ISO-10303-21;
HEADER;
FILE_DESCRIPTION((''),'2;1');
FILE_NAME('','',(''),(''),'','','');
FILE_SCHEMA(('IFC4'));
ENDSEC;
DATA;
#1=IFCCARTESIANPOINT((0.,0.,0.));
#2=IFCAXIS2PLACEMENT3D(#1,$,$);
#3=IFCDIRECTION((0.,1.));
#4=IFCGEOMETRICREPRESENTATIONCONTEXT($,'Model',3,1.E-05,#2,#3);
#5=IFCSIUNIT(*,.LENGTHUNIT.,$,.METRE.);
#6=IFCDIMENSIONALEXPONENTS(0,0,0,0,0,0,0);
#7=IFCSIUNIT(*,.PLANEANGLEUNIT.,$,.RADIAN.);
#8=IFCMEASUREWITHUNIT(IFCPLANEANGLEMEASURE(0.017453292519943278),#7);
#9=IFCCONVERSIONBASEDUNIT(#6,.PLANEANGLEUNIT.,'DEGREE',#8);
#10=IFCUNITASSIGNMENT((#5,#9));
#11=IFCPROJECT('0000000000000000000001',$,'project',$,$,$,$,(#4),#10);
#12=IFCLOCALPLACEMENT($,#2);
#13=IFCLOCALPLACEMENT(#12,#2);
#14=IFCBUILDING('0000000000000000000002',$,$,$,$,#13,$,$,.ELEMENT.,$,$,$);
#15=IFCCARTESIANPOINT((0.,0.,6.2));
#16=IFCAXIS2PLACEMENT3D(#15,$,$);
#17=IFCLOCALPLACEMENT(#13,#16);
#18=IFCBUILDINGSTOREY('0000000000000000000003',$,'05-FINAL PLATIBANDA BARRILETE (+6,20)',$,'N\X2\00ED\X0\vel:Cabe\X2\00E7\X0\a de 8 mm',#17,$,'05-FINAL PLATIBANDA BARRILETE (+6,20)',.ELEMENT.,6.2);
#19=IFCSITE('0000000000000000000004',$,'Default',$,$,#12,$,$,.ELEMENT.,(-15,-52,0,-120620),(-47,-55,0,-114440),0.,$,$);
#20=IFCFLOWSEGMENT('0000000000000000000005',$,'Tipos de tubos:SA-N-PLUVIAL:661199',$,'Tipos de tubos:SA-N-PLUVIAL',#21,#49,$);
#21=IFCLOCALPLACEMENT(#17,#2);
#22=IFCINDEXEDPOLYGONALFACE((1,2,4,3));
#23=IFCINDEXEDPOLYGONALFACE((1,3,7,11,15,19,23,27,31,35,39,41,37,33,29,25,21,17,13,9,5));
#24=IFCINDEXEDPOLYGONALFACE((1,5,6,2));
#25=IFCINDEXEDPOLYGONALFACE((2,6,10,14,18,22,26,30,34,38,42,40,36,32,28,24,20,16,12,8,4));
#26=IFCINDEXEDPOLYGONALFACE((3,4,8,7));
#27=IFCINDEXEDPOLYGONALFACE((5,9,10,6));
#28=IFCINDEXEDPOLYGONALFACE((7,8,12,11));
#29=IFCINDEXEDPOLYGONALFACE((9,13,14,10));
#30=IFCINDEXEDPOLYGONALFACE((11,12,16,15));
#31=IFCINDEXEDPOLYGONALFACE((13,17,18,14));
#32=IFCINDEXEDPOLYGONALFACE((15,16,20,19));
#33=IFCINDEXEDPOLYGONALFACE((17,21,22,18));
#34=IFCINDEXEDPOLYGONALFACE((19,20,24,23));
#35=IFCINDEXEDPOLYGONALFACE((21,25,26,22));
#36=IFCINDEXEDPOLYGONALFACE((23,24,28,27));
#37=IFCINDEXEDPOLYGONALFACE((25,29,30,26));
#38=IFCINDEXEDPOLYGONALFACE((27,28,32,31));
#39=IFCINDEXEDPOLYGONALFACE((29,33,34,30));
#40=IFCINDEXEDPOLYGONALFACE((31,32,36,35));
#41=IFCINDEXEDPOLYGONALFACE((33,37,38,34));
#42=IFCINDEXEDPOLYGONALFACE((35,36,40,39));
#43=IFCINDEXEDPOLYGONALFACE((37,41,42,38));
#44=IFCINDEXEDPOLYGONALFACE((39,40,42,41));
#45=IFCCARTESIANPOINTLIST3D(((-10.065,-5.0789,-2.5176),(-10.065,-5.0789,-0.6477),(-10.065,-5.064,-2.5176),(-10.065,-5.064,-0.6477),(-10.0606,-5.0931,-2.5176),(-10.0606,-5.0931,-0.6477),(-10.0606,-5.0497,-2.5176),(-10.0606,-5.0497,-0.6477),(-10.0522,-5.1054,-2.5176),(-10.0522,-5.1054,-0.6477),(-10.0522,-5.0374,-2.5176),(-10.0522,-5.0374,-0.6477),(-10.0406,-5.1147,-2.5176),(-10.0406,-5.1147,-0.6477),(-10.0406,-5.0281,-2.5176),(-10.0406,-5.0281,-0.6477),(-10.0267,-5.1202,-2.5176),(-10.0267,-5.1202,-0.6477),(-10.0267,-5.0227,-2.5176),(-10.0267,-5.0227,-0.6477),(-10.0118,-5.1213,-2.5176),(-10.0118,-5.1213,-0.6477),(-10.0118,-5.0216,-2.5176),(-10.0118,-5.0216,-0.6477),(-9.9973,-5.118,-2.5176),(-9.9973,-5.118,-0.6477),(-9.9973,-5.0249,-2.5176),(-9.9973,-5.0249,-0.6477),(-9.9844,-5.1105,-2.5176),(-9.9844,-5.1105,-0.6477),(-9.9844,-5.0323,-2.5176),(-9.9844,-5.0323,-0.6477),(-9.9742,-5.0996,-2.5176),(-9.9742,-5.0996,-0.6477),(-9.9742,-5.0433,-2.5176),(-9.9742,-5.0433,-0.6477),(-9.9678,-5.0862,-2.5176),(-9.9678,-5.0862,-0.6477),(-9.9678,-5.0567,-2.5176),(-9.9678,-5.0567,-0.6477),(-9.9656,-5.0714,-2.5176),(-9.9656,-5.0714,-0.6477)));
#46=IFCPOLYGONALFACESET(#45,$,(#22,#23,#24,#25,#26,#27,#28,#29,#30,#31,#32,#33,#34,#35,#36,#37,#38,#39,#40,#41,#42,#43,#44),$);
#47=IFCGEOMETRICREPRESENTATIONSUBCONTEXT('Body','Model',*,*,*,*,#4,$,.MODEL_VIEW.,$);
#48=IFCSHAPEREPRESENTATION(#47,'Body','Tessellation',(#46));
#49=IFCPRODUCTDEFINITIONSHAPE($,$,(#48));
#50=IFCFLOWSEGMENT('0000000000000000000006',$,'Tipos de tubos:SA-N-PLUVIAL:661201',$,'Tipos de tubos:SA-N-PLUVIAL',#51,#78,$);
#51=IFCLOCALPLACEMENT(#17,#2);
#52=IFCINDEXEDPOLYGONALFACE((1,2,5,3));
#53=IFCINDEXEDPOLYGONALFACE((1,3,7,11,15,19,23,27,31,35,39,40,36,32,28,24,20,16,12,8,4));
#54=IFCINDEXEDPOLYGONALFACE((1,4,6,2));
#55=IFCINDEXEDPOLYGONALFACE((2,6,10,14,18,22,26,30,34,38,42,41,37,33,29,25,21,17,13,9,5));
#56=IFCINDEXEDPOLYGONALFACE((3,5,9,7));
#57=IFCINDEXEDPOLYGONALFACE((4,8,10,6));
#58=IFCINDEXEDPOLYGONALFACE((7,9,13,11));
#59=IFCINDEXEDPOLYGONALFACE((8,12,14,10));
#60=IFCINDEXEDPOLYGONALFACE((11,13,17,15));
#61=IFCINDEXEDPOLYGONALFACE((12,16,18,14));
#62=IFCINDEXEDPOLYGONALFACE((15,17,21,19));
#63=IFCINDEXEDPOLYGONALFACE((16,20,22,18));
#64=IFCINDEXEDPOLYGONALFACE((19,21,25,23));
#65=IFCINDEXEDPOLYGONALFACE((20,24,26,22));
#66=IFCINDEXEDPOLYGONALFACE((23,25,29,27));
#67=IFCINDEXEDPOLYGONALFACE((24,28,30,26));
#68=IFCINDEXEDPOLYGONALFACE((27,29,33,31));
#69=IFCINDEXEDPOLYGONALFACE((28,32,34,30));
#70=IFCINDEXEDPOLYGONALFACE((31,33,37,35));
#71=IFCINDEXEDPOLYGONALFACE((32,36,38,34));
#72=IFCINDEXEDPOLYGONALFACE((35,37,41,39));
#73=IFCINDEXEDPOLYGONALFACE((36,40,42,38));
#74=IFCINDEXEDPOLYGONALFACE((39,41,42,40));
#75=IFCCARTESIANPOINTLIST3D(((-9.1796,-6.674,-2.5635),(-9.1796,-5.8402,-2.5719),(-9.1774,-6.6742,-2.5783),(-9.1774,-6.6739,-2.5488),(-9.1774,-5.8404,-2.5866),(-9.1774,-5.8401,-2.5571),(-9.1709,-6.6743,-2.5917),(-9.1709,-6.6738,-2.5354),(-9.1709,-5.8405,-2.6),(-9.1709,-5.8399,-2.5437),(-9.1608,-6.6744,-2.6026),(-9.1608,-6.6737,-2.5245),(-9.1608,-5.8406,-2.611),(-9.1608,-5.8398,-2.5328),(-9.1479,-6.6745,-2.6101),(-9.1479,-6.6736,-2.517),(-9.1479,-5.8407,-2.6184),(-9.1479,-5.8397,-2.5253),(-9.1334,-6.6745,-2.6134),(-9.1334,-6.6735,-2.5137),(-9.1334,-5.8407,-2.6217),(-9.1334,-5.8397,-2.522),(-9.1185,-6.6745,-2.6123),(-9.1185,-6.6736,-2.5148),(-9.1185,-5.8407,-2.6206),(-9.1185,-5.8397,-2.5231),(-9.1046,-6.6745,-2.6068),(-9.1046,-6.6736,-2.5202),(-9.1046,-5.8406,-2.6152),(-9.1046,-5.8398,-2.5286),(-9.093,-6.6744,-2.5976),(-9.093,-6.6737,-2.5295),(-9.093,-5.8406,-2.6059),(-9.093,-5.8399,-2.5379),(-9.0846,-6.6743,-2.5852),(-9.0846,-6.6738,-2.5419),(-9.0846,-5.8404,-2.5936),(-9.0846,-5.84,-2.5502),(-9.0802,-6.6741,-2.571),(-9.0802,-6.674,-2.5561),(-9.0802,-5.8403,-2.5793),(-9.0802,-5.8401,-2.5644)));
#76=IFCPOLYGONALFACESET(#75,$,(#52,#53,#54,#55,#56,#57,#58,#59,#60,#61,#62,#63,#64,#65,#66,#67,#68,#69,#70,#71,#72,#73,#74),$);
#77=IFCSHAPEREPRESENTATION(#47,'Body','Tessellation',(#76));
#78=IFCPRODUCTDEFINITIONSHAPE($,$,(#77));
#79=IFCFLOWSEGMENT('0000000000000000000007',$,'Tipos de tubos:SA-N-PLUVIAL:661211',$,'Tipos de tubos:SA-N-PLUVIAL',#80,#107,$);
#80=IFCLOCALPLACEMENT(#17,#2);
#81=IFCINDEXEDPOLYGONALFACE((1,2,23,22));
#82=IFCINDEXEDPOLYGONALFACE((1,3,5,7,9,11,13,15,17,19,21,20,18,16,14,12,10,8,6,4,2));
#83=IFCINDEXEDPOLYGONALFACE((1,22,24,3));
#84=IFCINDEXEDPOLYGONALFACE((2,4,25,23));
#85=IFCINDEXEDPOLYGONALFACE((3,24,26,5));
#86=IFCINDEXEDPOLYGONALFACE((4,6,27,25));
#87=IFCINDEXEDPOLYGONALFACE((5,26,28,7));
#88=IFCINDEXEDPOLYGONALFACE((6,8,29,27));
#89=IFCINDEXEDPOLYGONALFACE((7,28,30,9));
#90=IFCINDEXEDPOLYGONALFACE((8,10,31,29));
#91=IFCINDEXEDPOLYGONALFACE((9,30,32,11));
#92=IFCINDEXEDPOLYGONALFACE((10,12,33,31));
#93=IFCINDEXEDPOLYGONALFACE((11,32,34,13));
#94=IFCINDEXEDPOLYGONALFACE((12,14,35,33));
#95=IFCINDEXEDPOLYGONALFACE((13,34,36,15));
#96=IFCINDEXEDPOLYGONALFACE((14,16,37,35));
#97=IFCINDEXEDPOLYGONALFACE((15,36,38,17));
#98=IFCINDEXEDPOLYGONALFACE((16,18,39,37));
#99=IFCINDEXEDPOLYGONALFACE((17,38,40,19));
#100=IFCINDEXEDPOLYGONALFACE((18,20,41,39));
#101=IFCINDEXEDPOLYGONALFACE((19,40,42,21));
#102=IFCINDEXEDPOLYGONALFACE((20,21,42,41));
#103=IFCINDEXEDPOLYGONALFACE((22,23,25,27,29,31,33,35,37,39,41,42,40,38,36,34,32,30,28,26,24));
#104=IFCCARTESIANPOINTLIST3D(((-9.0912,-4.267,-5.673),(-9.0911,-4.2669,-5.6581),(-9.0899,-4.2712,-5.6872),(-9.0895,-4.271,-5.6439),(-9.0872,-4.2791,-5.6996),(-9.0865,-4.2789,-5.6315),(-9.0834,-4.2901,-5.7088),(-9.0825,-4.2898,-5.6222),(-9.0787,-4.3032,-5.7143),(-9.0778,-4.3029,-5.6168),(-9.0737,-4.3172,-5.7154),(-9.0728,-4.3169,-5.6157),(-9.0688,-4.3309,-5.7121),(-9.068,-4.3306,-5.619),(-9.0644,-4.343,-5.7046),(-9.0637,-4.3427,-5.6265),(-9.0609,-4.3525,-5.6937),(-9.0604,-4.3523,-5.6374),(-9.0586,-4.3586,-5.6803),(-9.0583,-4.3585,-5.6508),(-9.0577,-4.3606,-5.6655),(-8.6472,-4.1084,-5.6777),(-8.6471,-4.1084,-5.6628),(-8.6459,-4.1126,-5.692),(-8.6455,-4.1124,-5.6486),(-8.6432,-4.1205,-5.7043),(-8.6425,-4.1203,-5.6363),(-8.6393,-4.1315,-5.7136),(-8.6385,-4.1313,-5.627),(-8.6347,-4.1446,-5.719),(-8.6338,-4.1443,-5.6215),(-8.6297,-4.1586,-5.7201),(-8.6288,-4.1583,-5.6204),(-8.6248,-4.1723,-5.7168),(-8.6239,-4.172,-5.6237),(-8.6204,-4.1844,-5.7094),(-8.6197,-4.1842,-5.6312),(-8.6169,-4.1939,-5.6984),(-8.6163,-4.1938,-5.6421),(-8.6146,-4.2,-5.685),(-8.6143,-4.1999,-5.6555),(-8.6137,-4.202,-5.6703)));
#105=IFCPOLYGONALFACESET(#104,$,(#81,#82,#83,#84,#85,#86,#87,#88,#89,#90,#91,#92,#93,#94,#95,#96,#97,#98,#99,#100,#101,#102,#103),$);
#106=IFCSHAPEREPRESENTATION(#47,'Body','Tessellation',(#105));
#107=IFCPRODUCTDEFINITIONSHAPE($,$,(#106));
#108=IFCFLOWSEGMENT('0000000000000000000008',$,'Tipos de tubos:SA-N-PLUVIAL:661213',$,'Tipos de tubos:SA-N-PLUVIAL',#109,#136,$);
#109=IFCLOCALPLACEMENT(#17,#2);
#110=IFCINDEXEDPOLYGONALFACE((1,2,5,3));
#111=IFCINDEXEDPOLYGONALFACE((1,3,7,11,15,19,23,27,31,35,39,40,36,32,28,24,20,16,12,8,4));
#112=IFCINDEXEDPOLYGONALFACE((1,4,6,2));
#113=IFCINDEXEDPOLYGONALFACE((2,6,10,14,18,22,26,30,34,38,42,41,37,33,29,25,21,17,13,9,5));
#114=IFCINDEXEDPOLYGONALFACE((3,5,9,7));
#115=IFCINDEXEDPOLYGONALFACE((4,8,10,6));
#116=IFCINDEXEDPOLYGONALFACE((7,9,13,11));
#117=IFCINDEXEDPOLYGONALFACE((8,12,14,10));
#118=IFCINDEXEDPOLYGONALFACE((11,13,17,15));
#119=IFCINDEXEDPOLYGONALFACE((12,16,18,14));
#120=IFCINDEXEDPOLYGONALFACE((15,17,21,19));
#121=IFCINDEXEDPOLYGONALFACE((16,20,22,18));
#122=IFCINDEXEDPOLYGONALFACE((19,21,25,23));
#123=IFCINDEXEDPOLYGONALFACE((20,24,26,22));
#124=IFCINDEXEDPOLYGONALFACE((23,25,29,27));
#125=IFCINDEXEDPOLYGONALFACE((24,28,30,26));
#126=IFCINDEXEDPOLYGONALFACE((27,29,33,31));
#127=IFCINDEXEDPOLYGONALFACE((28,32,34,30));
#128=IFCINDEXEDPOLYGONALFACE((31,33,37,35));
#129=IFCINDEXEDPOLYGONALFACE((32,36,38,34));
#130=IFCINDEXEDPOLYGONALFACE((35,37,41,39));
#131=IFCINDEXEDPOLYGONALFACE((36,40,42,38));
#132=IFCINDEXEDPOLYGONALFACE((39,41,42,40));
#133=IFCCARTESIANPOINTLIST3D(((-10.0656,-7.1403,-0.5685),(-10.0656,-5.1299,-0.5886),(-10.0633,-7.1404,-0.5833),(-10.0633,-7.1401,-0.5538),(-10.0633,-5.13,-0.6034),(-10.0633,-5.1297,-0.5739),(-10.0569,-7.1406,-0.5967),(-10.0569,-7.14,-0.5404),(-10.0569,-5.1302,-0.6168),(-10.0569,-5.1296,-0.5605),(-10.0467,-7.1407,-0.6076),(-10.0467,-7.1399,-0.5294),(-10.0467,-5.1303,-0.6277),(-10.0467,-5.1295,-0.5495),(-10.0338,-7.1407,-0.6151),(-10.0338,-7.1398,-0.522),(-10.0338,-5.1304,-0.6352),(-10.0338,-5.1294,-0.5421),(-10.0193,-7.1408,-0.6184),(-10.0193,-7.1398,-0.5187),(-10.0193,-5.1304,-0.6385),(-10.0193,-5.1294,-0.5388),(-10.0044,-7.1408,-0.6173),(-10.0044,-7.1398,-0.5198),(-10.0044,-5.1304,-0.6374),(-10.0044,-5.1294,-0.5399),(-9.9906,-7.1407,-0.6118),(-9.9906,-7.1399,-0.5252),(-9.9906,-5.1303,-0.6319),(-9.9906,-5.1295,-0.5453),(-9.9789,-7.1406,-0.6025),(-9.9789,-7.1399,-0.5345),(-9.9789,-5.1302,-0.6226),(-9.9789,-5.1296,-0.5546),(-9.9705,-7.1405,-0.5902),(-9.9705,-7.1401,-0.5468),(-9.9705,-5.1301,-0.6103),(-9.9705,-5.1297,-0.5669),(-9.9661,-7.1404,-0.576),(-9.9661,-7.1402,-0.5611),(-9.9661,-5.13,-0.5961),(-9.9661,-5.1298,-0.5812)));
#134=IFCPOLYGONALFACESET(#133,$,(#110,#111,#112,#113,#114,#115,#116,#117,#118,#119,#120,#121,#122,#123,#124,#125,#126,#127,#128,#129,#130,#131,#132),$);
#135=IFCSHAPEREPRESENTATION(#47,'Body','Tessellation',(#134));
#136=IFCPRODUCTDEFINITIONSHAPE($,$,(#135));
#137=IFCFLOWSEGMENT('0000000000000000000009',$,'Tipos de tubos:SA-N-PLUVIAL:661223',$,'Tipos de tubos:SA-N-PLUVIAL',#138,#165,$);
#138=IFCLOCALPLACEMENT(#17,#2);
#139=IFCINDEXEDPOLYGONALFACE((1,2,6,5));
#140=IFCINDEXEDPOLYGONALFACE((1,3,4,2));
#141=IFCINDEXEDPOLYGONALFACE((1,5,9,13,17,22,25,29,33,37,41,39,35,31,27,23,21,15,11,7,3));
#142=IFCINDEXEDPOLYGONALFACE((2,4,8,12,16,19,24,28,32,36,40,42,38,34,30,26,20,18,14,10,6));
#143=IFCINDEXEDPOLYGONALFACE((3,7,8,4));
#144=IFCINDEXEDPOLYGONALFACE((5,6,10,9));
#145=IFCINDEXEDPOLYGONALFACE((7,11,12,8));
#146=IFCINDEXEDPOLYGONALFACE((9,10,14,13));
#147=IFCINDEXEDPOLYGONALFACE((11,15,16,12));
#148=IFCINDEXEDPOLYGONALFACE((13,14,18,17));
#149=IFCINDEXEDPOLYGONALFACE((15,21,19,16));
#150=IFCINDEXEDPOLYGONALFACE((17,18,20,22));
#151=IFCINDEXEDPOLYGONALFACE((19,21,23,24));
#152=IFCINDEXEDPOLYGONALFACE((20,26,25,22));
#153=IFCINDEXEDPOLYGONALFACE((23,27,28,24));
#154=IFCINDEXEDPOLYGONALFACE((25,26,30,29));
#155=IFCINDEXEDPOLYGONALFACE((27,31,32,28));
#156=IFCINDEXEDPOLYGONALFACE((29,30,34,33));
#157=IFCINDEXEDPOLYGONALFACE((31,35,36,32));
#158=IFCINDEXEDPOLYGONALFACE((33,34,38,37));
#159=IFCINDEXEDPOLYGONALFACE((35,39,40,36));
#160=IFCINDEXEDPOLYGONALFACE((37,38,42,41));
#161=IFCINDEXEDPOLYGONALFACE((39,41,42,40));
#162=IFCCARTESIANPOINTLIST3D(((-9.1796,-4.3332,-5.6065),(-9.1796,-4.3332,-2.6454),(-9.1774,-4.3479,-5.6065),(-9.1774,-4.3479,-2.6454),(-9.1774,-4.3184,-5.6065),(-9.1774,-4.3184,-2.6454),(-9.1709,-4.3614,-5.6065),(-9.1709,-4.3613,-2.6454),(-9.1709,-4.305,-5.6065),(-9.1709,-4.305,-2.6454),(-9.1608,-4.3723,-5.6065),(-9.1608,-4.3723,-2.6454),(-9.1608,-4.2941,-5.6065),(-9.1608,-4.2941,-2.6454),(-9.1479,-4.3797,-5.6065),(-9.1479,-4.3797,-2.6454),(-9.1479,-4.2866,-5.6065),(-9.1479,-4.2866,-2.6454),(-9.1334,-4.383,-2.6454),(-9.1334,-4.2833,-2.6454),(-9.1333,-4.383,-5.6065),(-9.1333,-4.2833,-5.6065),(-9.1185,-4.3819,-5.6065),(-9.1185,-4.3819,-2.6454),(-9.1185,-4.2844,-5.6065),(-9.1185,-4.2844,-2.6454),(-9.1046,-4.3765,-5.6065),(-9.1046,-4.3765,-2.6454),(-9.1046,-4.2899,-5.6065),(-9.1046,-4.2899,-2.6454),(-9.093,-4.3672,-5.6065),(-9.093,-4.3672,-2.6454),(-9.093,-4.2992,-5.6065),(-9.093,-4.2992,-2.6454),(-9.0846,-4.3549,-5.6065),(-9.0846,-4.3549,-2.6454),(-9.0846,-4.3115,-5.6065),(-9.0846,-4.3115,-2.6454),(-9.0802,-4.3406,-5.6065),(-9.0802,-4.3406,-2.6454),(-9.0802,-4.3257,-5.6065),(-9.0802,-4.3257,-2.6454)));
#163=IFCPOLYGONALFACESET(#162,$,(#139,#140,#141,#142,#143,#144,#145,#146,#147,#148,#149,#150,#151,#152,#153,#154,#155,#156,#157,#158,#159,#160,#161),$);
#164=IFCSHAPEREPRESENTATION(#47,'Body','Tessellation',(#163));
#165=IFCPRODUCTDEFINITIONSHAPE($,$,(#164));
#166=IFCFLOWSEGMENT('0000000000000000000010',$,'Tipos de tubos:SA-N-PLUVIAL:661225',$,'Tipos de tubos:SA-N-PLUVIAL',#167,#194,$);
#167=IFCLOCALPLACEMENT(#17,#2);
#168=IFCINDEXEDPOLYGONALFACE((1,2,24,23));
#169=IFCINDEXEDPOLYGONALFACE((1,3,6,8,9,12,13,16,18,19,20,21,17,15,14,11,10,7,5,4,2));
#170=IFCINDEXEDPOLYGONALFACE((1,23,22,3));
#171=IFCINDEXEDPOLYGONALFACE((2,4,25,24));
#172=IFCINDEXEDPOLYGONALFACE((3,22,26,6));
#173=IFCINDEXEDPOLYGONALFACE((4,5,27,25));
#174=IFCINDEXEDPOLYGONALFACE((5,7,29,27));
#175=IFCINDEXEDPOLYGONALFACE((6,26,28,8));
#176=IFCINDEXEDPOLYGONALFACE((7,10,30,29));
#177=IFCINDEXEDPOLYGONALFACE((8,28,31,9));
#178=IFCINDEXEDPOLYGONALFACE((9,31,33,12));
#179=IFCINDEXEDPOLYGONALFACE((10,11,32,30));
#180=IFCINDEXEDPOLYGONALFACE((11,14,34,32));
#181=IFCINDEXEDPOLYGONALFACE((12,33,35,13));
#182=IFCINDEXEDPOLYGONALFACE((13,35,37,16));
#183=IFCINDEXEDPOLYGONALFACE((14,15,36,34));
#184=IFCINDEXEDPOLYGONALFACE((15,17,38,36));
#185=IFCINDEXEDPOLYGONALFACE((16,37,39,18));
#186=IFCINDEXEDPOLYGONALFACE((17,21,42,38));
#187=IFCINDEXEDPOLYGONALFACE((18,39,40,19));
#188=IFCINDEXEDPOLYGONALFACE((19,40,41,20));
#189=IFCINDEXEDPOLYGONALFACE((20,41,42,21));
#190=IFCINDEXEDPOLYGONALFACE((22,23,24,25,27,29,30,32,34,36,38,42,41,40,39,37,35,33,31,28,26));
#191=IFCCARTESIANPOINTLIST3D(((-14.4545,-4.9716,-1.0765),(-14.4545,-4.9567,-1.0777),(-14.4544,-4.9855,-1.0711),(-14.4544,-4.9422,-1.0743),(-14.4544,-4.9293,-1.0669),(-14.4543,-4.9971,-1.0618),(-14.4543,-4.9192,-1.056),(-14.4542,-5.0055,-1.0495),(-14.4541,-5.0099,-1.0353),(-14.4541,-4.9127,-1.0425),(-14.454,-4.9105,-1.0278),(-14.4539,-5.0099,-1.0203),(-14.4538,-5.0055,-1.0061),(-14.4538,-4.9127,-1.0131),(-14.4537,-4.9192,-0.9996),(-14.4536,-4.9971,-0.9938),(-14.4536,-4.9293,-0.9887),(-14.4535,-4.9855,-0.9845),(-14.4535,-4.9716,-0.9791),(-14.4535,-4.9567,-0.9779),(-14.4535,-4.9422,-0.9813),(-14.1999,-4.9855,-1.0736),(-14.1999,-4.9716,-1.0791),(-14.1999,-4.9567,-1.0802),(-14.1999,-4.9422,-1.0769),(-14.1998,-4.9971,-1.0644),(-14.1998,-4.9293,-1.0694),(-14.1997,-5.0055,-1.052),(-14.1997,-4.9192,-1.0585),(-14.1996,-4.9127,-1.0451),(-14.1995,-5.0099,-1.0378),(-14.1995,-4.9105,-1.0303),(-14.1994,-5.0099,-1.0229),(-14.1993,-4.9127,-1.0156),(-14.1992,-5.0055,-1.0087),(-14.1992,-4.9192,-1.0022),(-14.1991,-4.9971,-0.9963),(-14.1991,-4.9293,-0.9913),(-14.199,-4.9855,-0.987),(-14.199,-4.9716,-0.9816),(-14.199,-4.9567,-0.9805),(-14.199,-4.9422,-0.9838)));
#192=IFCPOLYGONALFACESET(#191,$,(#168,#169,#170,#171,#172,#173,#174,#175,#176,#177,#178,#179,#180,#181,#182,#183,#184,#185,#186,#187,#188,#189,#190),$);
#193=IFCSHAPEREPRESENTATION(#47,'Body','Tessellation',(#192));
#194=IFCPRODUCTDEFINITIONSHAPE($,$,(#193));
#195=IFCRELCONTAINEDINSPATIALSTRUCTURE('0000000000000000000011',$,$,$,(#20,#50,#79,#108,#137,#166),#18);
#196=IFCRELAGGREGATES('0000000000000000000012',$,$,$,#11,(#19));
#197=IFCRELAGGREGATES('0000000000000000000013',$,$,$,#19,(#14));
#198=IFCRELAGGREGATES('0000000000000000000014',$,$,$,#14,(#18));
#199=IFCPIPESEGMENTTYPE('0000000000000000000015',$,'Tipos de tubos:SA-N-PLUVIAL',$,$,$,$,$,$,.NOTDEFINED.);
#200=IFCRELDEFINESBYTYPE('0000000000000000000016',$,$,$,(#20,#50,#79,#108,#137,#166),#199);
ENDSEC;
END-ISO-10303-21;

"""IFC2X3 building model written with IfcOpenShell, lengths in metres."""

from ifc_helpers import new_model, entity, si_unit, converted_unit, direction, frame, frame_2d, origin, origin_2d_with_axis, place, context, subcontext, project, spatial, circle, extrude, type_object, element, save


model = new_model("IFC2X3")

# Units and contexts
model_context = context("Model", 3, precision=1e-05, world=origin(), true_north=direction((0.0, 1.0)))
body_context = subcontext(model_context, "Body", "Model", "MODEL_VIEW")
ifc_project = project(units=[si_unit("LENGTHUNIT", "METRE"), converted_unit("PLANEANGLEUNIT", "DEGREE", entity("IfcPlaneAngleMeasure", 0.017453292519943278), si_unit("PLANEANGLEUNIT", "RADIAN"), dimensions=[0, 0, 0, 0, 0, 0, 0])], contexts=[model_context])

# Site, building, storey
site_placement = place(None, origin())
site = spatial("IfcSite", under=ifc_project, at=site_placement, Name="Default", CompositionType="ELEMENT", RefLatitude=(-15, -52, 0, -120620), RefLongitude=(-47, -55, 0, -114440), RefElevation=0.0)
building_placement = place(site_placement, origin())
building = spatial("IfcBuilding", under=site, at=building_placement, CompositionType="ELEMENT")
storey_placement = place(building_placement, frame((0.0, 0.0, 6.2)))
storey = spatial("IfcBuildingStorey", under=building, at=storey_placement, Name="05-FINAL PLATIBANDA BARRILETE (+6,20)", ObjectType="Nível:Cabeça de 8 mm", LongName="05-FINAL PLATIBANDA BARRILETE (+6,20)", CompositionType="ELEMENT", Elevation=6.2)

# Flow segments
pipe_segment_type = type_object("IfcPipeSegmentType", Name="Tipos de tubos:SA-N-PLUVIAL", PredefinedType="NOTDEFINED")
flow_segment_1_placement = place(storey_placement, origin())
element("IfcFlowSegment", 1, at=flow_segment_1_placement, inside=storey, type_object=pipe_segment_type, Name="Tipos de tubos:SA-N-PLUVIAL:661199", ObjectType="Tipos de tubos:SA-N-PLUVIAL", context=body_context, shape_type="SweptSolid", body=[
    extrude(circle(Radius=0.05, at=origin_2d_with_axis()), frame((-10.0156, -5.0714, -2.5176)), (0.0, 0.0, 1.0), 1.8699),
])
flow_segment_2_placement = place(storey_placement, origin())
element("IfcFlowSegment", 2, at=flow_segment_2_placement, inside=storey, type_object=pipe_segment_type, Name="Tipos de tubos:SA-N-PLUVIAL:661201", ObjectType="Tipos de tubos:SA-N-PLUVIAL", context=body_context, shape_type="SweptSolid", body=[
    extrude(circle(Radius=0.05, at=origin_2d_with_axis()), frame((-9.1296, -6.674, -2.5635), z_axis=(-0.000001, 0.99995, -0.01), x_axis=(-1.0, -0.000001, 0.0)), (0.0, 0.0, 1.0), 0.8339),
])
flow_segment_3_placement = place(storey_placement, origin())
element("IfcFlowSegment", 3, at=flow_segment_3_placement, inside=storey, type_object=pipe_segment_type, Name="Tipos de tubos:SA-N-PLUVIAL:661211", ObjectType="Tipos de tubos:SA-N-PLUVIAL", context=body_context, shape_type="SweptSolid", body=[
    extrude(circle(Radius=0.05, at=frame_2d((0.0, 0.0), x_axis=(1.0, 0.0))), frame((-9.0745, -4.3135, -5.6655), z_axis=(0.941701, 0.336302, -0.01), x_axis=(0.336319, -0.941748, 0.0)), (0.0, 0.0, 1.0), 0.4715),
])
flow_segment_4_placement = place(storey_placement, origin())
element("IfcFlowSegment", 4, at=flow_segment_4_placement, inside=storey, type_object=pipe_segment_type, Name="Tipos de tubos:SA-N-PLUVIAL:661213", ObjectType="Tipos de tubos:SA-N-PLUVIAL", context=body_context, shape_type="SweptSolid", body=[
    extrude(circle(Radius=0.05, at=origin_2d_with_axis()), frame((-10.0156, -7.1403, -0.5685), z_axis=(-0.000001, 0.99995, -0.01), x_axis=(-1.0, -0.000001, 0.0)), (0.0, 0.0, 1.0), 2.0105),
])
flow_segment_5_placement = place(storey_placement, origin())
element("IfcFlowSegment", 5, at=flow_segment_5_placement, inside=storey, type_object=pipe_segment_type, Name="Tipos de tubos:SA-N-PLUVIAL:661223", ObjectType="Tipos de tubos:SA-N-PLUVIAL", context=body_context, shape_type="SweptSolid", body=[
    extrude(circle(Radius=0.05, at=frame_2d((0.0, 0.0), x_axis=(1.0, 0.0))), frame((-9.1296, -4.3332, -5.6065), z_axis=(-0.000007, 0.000002, 1.0), x_axis=(-1.0, 0.0, -0.000007)), (0.0, 0.0, 1.0), 2.961),
])
flow_segment_6_placement = place(storey_placement, origin())
element("IfcFlowSegment", 6, at=flow_segment_6_placement, inside=storey, type_object=pipe_segment_type, Name="Tipos de tubos:SA-N-PLUVIAL:661225", ObjectType="Tipos de tubos:SA-N-PLUVIAL", context=body_context, shape_type="SweptSolid", body=[
    extrude(circle(Radius=0.05, at=frame_2d((0.0, 0.0), x_axis=(1.0, 0.0))), frame((-14.454, -4.9605, -1.0278), z_axis=(0.99995, 0.000001, -0.01), x_axis=(-0.000001, 1.0, 0.0)), (0.0, 0.0, 1.0), 0.2545),
])

save(model, "model.ifc")
